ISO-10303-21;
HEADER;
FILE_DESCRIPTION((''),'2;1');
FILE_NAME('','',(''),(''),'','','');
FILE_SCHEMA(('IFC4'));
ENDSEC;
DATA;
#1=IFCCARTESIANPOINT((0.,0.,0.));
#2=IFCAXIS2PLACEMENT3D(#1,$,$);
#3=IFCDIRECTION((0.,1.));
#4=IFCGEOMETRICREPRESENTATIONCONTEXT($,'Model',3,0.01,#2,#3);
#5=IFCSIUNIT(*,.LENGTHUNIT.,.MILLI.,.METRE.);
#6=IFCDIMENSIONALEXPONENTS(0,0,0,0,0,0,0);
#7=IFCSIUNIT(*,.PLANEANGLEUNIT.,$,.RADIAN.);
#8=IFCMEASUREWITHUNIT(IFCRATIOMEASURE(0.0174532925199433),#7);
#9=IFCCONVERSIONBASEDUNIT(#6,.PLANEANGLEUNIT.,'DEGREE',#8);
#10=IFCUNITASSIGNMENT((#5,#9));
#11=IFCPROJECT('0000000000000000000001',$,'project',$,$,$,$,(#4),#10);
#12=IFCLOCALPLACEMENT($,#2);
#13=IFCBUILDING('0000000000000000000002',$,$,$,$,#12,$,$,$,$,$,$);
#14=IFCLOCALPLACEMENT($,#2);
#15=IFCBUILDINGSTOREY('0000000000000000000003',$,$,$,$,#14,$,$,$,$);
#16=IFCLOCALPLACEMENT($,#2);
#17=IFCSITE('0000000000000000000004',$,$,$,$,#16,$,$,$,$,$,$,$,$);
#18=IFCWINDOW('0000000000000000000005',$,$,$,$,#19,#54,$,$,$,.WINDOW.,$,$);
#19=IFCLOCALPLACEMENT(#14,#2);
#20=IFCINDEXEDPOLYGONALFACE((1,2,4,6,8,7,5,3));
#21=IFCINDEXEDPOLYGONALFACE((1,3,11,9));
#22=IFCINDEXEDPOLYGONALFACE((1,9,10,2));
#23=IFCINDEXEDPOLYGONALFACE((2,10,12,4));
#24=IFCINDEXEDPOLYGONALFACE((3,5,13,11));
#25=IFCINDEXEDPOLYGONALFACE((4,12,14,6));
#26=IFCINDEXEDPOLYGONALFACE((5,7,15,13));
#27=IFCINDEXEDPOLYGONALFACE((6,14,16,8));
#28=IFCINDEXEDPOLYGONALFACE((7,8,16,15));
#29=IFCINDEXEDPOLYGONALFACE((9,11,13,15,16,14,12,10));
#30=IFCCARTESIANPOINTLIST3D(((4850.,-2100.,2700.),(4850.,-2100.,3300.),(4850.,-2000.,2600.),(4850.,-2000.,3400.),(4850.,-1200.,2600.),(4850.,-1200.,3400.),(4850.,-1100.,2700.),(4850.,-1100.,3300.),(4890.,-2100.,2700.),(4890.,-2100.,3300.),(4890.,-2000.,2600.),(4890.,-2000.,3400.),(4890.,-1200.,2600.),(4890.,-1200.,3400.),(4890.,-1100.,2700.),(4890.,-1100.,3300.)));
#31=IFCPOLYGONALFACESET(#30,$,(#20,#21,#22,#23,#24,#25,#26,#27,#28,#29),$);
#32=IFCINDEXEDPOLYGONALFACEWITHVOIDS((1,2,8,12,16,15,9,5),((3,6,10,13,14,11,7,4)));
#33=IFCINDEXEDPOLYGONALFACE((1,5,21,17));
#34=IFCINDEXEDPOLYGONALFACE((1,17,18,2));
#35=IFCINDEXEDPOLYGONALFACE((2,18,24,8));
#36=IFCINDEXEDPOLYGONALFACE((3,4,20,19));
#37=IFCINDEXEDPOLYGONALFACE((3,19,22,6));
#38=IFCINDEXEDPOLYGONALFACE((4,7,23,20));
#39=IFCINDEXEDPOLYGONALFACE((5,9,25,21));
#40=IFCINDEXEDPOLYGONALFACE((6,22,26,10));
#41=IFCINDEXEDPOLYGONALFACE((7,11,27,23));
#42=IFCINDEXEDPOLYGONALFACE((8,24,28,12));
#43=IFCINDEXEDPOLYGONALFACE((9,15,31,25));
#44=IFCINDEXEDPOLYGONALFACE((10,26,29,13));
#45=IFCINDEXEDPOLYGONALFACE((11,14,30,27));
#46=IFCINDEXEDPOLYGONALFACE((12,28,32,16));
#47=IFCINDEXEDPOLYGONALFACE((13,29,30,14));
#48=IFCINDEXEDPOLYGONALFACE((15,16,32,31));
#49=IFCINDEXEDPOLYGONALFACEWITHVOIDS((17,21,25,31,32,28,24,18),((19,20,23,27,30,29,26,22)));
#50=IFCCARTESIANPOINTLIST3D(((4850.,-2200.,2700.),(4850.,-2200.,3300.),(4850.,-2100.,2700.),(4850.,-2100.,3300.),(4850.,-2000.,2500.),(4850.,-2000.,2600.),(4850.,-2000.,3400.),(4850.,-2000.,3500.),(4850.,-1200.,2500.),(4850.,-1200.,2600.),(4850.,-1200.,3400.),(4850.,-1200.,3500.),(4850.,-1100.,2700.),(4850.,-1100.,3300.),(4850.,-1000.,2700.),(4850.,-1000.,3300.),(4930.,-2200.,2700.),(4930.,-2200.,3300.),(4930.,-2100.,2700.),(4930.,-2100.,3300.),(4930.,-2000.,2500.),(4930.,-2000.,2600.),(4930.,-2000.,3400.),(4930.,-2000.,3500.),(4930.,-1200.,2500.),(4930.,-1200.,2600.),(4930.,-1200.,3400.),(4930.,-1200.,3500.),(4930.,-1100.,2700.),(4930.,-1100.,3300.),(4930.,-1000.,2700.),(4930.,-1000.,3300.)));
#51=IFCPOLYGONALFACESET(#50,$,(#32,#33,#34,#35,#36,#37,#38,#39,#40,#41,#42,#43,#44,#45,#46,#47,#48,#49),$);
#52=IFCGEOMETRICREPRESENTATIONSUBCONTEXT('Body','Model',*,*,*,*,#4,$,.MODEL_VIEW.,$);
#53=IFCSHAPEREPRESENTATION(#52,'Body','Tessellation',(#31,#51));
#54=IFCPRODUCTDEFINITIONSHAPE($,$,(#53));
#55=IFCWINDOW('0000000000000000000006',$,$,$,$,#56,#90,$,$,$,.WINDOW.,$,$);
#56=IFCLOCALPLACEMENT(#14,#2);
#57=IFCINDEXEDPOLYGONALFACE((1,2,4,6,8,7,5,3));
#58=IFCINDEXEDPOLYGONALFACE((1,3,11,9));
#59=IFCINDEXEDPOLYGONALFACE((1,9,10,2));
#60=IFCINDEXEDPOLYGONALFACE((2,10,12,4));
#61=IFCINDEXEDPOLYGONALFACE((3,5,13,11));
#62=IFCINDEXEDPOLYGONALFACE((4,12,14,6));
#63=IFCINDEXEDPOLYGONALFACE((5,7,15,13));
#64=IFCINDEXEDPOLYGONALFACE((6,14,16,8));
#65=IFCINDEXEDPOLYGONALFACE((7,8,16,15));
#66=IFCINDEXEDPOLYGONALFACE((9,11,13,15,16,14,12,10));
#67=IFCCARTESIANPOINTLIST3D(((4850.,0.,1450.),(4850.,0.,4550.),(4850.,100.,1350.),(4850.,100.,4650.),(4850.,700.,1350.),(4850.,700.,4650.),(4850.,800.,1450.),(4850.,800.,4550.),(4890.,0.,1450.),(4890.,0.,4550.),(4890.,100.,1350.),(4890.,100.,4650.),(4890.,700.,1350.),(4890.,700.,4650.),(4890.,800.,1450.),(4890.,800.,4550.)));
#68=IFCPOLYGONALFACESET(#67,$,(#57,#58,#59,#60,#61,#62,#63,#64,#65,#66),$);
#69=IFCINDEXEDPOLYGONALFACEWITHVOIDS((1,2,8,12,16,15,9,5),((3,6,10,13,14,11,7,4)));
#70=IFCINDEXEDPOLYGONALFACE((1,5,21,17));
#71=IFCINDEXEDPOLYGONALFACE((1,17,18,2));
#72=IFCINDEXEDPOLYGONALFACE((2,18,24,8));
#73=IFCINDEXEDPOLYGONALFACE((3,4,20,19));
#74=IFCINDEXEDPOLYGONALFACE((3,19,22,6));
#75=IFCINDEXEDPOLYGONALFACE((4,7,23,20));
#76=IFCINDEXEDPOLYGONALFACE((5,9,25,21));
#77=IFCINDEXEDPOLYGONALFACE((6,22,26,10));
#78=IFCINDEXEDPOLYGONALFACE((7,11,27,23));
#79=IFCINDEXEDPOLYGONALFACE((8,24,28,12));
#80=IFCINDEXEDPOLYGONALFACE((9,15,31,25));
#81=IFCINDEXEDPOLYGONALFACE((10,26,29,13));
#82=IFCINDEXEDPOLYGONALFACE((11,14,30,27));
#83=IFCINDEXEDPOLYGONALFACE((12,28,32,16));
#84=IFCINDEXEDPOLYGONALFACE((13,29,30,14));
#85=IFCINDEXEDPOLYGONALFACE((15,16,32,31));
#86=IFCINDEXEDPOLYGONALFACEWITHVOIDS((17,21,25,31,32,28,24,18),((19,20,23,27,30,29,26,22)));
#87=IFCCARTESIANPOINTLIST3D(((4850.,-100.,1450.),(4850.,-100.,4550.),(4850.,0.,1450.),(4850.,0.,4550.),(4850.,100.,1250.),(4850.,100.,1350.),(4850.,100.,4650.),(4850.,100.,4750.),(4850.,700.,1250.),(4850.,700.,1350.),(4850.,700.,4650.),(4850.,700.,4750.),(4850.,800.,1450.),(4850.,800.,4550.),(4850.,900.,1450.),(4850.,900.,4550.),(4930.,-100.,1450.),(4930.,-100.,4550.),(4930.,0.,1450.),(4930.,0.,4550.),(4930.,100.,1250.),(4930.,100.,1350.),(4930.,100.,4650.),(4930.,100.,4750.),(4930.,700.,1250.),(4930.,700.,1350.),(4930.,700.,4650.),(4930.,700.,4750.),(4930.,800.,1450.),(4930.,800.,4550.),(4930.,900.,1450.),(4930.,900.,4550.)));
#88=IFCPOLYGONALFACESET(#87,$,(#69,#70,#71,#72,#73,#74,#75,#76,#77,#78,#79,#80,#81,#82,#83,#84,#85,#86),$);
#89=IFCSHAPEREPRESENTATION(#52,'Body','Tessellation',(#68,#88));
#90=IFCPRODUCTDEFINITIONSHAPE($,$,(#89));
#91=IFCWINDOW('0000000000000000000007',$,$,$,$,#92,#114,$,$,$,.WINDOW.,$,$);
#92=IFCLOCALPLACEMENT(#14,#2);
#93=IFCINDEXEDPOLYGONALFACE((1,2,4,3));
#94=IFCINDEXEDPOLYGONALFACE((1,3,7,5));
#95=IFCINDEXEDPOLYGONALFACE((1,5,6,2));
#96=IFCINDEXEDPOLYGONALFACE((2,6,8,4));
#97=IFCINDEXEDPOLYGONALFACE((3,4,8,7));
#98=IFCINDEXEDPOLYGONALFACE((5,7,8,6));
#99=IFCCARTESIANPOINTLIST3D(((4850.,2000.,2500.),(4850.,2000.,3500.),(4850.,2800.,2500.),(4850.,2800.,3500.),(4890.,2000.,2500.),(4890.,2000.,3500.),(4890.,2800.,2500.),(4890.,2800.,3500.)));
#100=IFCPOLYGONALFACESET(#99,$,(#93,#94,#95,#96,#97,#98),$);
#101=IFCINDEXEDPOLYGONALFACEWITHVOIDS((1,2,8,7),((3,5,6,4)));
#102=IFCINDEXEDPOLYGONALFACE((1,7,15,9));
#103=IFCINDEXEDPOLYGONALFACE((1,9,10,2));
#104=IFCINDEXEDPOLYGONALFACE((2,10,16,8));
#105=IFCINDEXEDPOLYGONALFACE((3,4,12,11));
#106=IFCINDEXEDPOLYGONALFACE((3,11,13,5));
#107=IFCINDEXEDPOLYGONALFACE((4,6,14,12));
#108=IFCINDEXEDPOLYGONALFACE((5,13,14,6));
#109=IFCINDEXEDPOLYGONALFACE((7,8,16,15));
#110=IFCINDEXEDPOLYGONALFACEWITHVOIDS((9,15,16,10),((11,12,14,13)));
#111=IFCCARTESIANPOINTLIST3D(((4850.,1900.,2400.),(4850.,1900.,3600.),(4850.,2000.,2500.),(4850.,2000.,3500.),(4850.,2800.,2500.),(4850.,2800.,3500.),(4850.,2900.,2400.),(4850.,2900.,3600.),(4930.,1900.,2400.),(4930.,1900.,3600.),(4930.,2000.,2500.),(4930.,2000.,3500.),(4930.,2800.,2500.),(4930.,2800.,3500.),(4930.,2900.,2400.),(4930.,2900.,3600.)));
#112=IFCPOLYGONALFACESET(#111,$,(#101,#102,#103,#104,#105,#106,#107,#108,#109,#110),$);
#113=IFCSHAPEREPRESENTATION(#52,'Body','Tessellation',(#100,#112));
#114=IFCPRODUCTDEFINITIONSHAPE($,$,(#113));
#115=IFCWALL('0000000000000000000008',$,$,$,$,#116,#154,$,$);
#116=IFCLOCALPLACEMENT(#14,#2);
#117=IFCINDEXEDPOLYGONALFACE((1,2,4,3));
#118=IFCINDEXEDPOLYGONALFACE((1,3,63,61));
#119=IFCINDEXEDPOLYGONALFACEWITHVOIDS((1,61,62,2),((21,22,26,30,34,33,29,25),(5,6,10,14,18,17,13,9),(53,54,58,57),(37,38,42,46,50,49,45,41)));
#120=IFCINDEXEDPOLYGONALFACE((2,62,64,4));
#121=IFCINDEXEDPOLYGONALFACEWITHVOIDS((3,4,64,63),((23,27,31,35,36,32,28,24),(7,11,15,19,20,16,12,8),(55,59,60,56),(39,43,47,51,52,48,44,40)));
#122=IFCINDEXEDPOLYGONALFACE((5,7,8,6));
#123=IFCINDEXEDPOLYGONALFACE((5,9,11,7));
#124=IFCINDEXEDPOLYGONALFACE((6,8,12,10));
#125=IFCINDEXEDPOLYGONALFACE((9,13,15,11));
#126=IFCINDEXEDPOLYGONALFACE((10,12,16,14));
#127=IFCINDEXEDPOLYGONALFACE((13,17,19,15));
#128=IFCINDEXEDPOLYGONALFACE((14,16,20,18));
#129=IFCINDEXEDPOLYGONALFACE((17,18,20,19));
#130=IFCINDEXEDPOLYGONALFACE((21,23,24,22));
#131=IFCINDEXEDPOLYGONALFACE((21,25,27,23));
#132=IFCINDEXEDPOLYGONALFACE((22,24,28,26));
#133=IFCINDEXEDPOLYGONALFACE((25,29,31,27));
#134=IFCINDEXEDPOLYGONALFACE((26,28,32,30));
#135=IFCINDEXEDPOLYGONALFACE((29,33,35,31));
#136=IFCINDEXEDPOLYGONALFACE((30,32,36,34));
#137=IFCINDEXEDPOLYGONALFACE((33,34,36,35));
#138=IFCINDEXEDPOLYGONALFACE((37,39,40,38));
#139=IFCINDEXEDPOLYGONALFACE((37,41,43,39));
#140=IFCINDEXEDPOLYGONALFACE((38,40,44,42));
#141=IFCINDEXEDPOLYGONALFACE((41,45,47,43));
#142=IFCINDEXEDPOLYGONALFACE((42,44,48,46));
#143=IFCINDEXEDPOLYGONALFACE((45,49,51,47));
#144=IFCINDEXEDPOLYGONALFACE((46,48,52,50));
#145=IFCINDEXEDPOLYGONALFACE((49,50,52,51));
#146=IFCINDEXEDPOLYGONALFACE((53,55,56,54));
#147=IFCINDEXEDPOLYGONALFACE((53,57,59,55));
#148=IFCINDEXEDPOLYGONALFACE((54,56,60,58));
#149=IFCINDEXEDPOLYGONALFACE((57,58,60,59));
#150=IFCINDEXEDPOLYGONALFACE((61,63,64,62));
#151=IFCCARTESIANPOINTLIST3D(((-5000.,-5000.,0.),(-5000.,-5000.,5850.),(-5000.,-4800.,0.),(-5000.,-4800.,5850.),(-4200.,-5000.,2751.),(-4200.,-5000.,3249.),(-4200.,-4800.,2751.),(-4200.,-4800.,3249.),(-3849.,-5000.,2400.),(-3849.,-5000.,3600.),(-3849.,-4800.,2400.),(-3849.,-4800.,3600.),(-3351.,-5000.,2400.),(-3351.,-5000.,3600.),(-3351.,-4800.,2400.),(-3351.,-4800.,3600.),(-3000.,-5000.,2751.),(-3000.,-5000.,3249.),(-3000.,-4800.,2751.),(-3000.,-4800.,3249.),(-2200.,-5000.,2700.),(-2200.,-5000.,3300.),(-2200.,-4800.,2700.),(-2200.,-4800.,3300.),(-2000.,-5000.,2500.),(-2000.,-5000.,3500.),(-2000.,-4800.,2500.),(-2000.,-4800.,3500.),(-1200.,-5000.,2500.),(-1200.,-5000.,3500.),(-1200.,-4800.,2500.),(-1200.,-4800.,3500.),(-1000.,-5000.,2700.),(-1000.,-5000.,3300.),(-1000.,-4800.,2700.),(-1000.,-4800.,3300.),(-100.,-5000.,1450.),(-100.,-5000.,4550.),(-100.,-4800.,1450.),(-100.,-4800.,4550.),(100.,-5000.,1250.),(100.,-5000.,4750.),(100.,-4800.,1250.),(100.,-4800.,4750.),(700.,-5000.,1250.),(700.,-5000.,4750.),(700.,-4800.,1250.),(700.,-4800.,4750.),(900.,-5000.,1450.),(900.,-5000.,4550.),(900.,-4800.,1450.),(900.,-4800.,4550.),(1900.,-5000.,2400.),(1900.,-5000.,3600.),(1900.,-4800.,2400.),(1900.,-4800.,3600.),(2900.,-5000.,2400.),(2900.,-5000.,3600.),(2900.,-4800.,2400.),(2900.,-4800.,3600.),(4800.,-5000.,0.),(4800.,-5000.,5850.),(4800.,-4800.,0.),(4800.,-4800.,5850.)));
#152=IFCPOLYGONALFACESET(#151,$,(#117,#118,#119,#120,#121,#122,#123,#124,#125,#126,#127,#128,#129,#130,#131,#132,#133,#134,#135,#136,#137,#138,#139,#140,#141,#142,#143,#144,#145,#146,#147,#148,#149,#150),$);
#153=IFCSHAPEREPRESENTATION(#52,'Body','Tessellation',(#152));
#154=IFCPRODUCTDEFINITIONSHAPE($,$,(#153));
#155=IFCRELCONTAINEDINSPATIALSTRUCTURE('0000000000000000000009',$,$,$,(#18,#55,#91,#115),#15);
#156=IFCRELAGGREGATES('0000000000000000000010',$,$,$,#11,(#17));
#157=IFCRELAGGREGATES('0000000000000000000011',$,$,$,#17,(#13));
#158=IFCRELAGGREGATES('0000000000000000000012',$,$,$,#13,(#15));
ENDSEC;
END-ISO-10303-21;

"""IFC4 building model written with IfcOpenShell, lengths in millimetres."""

from ifc_helpers import new_model, entity, si_unit, converted_unit, direction, frame, origin, origin_2d, place, context, subcontext, project, spatial, polyline, rectangle, outline, extrude, element, save


model = new_model("IFC4")

# Units and contexts
model_context = context("Model", 3, precision=0.01, world=origin(), true_north=direction((0.0, 1.0)))
body_context = subcontext(model_context, "Body", "Model", "MODEL_VIEW")
ifc_project = project(units=[si_unit("LENGTHUNIT", "METRE", prefix="MILLI"), converted_unit("PLANEANGLEUNIT", "DEGREE", entity("IfcRatioMeasure", 0.0174532925199433), si_unit("PLANEANGLEUNIT", "RADIAN"), dimensions=[0, 0, 0, 0, 0, 0, 0])], contexts=[model_context])

# Site, building, storey
site_placement = place(None, origin())
site = spatial("IfcSite", under=ifc_project, at=site_placement)
building_placement = place(None, origin())
building = spatial("IfcBuilding", under=site, at=building_placement)
storey_placement = place(None, origin())
storey = spatial("IfcBuildingStorey", under=building, at=storey_placement)

# Shared definitions
cartesian_point_1 = entity("IfcCartesianPoint", [-500.0, -300.0])
shared_polyline_1 = entity("IfcPolyline", [cartesian_point_1, entity("IfcCartesianPoint", [-500.0, 300.0]), entity("IfcCartesianPoint", [-400.0, 400.0]), entity("IfcCartesianPoint", [400.0, 400.0]), entity("IfcCartesianPoint", [500.0, 300.0]), entity("IfcCartesianPoint", [500.0, -300.0]), entity("IfcCartesianPoint", [400.0, -400.0]), entity("IfcCartesianPoint", [-400.0, -400.0]), cartesian_point_1])
cartesian_point_2 = entity("IfcCartesianPoint", [-400.0, -1550.0])
shared_polyline_2 = entity("IfcPolyline", [cartesian_point_2, entity("IfcCartesianPoint", [-400.0, 1550.0]), entity("IfcCartesianPoint", [-300.0, 1650.0]), entity("IfcCartesianPoint", [300.0, 1650.0]), entity("IfcCartesianPoint", [400.0, 1550.0]), entity("IfcCartesianPoint", [400.0, -1550.0]), entity("IfcCartesianPoint", [300.0, -1650.0]), entity("IfcCartesianPoint", [-300.0, -1650.0]), cartesian_point_2])
cartesian_point_3 = entity("IfcCartesianPoint", [-400.0, -500.0])
shared_polyline_3 = entity("IfcPolyline", [cartesian_point_3, entity("IfcCartesianPoint", [-400.0, 500.0]), entity("IfcCartesianPoint", [-400.0, 500.0]), entity("IfcCartesianPoint", [400.0, 500.0]), entity("IfcCartesianPoint", [400.0, 500.0]), entity("IfcCartesianPoint", [400.0, -500.0]), entity("IfcCartesianPoint", [400.0, -500.0]), entity("IfcCartesianPoint", [-400.0, -500.0]), cartesian_point_3])

# Shared definitions
wall_1_placement = place(storey_placement, frame((4900.0, -100.0, 0.0), z_axis=(0.0, 0.0, 1.0), x_axis=(0.0, 1.0, 0.0)))
window_1_placement = place(wall_1_placement, frame((-1500.0, 50.0, 3000.0)))
window_2_placement = place(wall_1_placement, frame((500.0, 50.0, 3000.0)))
window_3_placement = place(wall_1_placement, frame((2500.0, 50.0, 3000.0)))

# Windows
cartesian_point_4 = entity("IfcCartesianPoint", [-600.0, -300.0])
element("IfcWindow", 1, at=window_1_placement, inside=storey, PredefinedType="WINDOW", context=body_context, shape_type="SweptSolid", body=[
    entity("IfcExtrudedAreaSolid", entity("IfcArbitraryClosedProfileDef", "AREA", None, shared_polyline_1), entity("IfcAxis2Placement3D", entity("IfcCartesianPoint", [0.0, 0.0, 0.0]), entity("IfcDirection", [0.0, -1.0, 0.0]), entity("IfcDirection", [1.0, 0.0, 0.0])), entity("IfcDirection", [0.0, 0.0, 1.0]), 40.0),
    entity("IfcExtrudedAreaSolid", entity("IfcArbitraryProfileDefWithVoids", "AREA", None, entity("IfcPolyline", [cartesian_point_4, entity("IfcCartesianPoint", [-600.0, 300.0]), entity("IfcCartesianPoint", [-400.0, 500.0]), entity("IfcCartesianPoint", [400.0, 500.0]), entity("IfcCartesianPoint", [600.0, 300.0]), entity("IfcCartesianPoint", [600.0, -300.0]), entity("IfcCartesianPoint", [400.0, -500.0]), entity("IfcCartesianPoint", [-400.0, -500.0]), cartesian_point_4]), [shared_polyline_1]), entity("IfcAxis2Placement3D", entity("IfcCartesianPoint", [0.0, 0.0, 0.0]), entity("IfcDirection", [0.0, -1.0, 0.0]), entity("IfcDirection", [1.0, 0.0, 0.0])), entity("IfcDirection", [0.0, 0.0, 1.0]), 80.0),
])
cartesian_point_5 = entity("IfcCartesianPoint", [-500.0, -1550.0])
element("IfcWindow", 2, at=window_2_placement, inside=storey, PredefinedType="WINDOW", context=body_context, shape_type="SweptSolid", body=[
    entity("IfcExtrudedAreaSolid", entity("IfcArbitraryClosedProfileDef", "AREA", None, shared_polyline_2), entity("IfcAxis2Placement3D", entity("IfcCartesianPoint", [0.0, 0.0, 0.0]), entity("IfcDirection", [0.0, -1.0, 0.0]), entity("IfcDirection", [1.0, 0.0, 0.0])), entity("IfcDirection", [0.0, 0.0, 1.0]), 40.0),
    entity("IfcExtrudedAreaSolid", entity("IfcArbitraryProfileDefWithVoids", "AREA", None, entity("IfcPolyline", [cartesian_point_5, entity("IfcCartesianPoint", [-500.0, 1550.0]), entity("IfcCartesianPoint", [-300.0, 1750.0]), entity("IfcCartesianPoint", [300.0, 1750.0]), entity("IfcCartesianPoint", [500.0, 1550.0]), entity("IfcCartesianPoint", [500.0, -1550.0]), entity("IfcCartesianPoint", [300.0, -1750.0]), entity("IfcCartesianPoint", [-300.0, -1750.0]), cartesian_point_5]), [shared_polyline_2]), entity("IfcAxis2Placement3D", entity("IfcCartesianPoint", [0.0, 0.0, 0.0]), entity("IfcDirection", [0.0, -1.0, 0.0]), entity("IfcDirection", [1.0, 0.0, 0.0])), entity("IfcDirection", [0.0, 0.0, 1.0]), 80.0),
])
cartesian_point_6 = entity("IfcCartesianPoint", [-500.0, -600.0])
element("IfcWindow", 3, at=window_3_placement, inside=storey, PredefinedType="WINDOW", context=body_context, shape_type="SweptSolid", body=[
    entity("IfcExtrudedAreaSolid", entity("IfcArbitraryClosedProfileDef", "AREA", None, shared_polyline_3), entity("IfcAxis2Placement3D", entity("IfcCartesianPoint", [0.0, 0.0, 0.0]), entity("IfcDirection", [0.0, -1.0, 0.0]), entity("IfcDirection", [1.0, 0.0, 0.0])), entity("IfcDirection", [0.0, 0.0, 1.0]), 40.0),
    entity("IfcExtrudedAreaSolid", entity("IfcArbitraryProfileDefWithVoids", "AREA", None, entity("IfcPolyline", [cartesian_point_6, entity("IfcCartesianPoint", [-500.0, 600.0]), entity("IfcCartesianPoint", [-500.0, 600.0]), entity("IfcCartesianPoint", [500.0, 600.0]), entity("IfcCartesianPoint", [500.0, 600.0]), entity("IfcCartesianPoint", [500.0, -600.0]), entity("IfcCartesianPoint", [500.0, -600.0]), entity("IfcCartesianPoint", [-500.0, -600.0]), cartesian_point_6]), [shared_polyline_3]), entity("IfcAxis2Placement3D", entity("IfcCartesianPoint", [0.0, 0.0, 0.0]), entity("IfcDirection", [0.0, -1.0, 0.0]), entity("IfcDirection", [1.0, 0.0, 0.0])), entity("IfcDirection", [0.0, 0.0, 1.0]), 80.0),
])

# Wall, openings
wall_2_placement = place(storey_placement, frame((-100.0, -4900.0, 0.0), z_axis=(0.0, 0.0, 1.0), x_axis=(1.0, 0.0, 0.0)))
wall_2 = element("IfcWall", 4, at=wall_2_placement, inside=storey, context=body_context, shape_type="SweptSolid", body=[
    extrude(rectangle(XDim=9800.0, YDim=200.0, at=origin_2d()), origin(), (0.0, 0.0, 1.0), 5850.0),
])
window_4_placement = place(wall_2_placement, frame((-3500.0, 50.0, 3000.0)))
opening_1_placement = place(window_4_placement, frame((0.0, 50.0, 0.0)))
element("IfcOpeningElement", 5, at=opening_1_placement, cuts=wall_2, context=body_context, shape_type="SweptSolid", body=[
    extrude(outline(polyline([(-600.0, -249.0), (-600.0, 249.0), (-249.0, 600.0), (249.0, 600.0), (600.0, 249.0), (600.0, -249.0), (249.0, -600.0), (-249.0, -600.0), (-600.0, -249.0)])), frame((0.0, 0.0, 0.0), z_axis=(0.0, -1.0, 0.0), x_axis=(1.0, 0.0, 0.0)), (0.0, 0.0, 1.0), 200.0),
])
window_5_placement = place(wall_2_placement, frame((-1500.0, 50.0, 3000.0)))
opening_2_placement = place(window_5_placement, frame((0.0, 50.0, 0.0)))
element("IfcOpeningElement", 6, at=opening_2_placement, cuts=wall_2, context=body_context, shape_type="SweptSolid", body=[
    extrude(outline(polyline([(-600.0, -300.0), (-600.0, 300.0), (-400.0, 500.0), (400.0, 500.0), (600.0, 300.0), (600.0, -300.0), (400.0, -500.0), (-400.0, -500.0), (-600.0, -300.0)])), frame((0.0, 0.0, 0.0), z_axis=(0.0, -1.0, 0.0), x_axis=(1.0, 0.0, 0.0)), (0.0, 0.0, 1.0), 200.0),
])
window_6_placement = place(wall_2_placement, frame((500.0, 50.0, 3000.0)))
opening_3_placement = place(window_6_placement, frame((0.0, 50.0, 0.0)))
element("IfcOpeningElement", 7, at=opening_3_placement, cuts=wall_2, context=body_context, shape_type="SweptSolid", body=[
    extrude(outline(polyline([(-500.0, -1550.0), (-500.0, 1550.0), (-300.0, 1750.0), (300.0, 1750.0), (500.0, 1550.0), (500.0, -1550.0), (300.0, -1750.0), (-300.0, -1750.0), (-500.0, -1550.0)])), frame((0.0, 0.0, 0.0), z_axis=(0.0, -1.0, 0.0), x_axis=(1.0, 0.0, 0.0)), (0.0, 0.0, 1.0), 200.0),
])
window_7_placement = place(wall_2_placement, frame((2500.0, 50.0, 3000.0)))
opening_4_placement = place(window_7_placement, frame((0.0, 50.0, 0.0)))
element("IfcOpeningElement", 8, at=opening_4_placement, cuts=wall_2, context=body_context, shape_type="SweptSolid", body=[
    extrude(outline(polyline([(-500.0, -600.0), (-500.0, 600.0), (-500.0, 600.0), (500.0, 600.0), (500.0, 600.0), (500.0, -600.0), (500.0, -600.0), (-500.0, -600.0), (-500.0, -600.0)])), frame((0.0, 0.0, 0.0), z_axis=(0.0, -1.0, 0.0), x_axis=(1.0, 0.0, 0.0)), (0.0, 0.0, 1.0), 200.0),
])

save(model, "model.ifc")
